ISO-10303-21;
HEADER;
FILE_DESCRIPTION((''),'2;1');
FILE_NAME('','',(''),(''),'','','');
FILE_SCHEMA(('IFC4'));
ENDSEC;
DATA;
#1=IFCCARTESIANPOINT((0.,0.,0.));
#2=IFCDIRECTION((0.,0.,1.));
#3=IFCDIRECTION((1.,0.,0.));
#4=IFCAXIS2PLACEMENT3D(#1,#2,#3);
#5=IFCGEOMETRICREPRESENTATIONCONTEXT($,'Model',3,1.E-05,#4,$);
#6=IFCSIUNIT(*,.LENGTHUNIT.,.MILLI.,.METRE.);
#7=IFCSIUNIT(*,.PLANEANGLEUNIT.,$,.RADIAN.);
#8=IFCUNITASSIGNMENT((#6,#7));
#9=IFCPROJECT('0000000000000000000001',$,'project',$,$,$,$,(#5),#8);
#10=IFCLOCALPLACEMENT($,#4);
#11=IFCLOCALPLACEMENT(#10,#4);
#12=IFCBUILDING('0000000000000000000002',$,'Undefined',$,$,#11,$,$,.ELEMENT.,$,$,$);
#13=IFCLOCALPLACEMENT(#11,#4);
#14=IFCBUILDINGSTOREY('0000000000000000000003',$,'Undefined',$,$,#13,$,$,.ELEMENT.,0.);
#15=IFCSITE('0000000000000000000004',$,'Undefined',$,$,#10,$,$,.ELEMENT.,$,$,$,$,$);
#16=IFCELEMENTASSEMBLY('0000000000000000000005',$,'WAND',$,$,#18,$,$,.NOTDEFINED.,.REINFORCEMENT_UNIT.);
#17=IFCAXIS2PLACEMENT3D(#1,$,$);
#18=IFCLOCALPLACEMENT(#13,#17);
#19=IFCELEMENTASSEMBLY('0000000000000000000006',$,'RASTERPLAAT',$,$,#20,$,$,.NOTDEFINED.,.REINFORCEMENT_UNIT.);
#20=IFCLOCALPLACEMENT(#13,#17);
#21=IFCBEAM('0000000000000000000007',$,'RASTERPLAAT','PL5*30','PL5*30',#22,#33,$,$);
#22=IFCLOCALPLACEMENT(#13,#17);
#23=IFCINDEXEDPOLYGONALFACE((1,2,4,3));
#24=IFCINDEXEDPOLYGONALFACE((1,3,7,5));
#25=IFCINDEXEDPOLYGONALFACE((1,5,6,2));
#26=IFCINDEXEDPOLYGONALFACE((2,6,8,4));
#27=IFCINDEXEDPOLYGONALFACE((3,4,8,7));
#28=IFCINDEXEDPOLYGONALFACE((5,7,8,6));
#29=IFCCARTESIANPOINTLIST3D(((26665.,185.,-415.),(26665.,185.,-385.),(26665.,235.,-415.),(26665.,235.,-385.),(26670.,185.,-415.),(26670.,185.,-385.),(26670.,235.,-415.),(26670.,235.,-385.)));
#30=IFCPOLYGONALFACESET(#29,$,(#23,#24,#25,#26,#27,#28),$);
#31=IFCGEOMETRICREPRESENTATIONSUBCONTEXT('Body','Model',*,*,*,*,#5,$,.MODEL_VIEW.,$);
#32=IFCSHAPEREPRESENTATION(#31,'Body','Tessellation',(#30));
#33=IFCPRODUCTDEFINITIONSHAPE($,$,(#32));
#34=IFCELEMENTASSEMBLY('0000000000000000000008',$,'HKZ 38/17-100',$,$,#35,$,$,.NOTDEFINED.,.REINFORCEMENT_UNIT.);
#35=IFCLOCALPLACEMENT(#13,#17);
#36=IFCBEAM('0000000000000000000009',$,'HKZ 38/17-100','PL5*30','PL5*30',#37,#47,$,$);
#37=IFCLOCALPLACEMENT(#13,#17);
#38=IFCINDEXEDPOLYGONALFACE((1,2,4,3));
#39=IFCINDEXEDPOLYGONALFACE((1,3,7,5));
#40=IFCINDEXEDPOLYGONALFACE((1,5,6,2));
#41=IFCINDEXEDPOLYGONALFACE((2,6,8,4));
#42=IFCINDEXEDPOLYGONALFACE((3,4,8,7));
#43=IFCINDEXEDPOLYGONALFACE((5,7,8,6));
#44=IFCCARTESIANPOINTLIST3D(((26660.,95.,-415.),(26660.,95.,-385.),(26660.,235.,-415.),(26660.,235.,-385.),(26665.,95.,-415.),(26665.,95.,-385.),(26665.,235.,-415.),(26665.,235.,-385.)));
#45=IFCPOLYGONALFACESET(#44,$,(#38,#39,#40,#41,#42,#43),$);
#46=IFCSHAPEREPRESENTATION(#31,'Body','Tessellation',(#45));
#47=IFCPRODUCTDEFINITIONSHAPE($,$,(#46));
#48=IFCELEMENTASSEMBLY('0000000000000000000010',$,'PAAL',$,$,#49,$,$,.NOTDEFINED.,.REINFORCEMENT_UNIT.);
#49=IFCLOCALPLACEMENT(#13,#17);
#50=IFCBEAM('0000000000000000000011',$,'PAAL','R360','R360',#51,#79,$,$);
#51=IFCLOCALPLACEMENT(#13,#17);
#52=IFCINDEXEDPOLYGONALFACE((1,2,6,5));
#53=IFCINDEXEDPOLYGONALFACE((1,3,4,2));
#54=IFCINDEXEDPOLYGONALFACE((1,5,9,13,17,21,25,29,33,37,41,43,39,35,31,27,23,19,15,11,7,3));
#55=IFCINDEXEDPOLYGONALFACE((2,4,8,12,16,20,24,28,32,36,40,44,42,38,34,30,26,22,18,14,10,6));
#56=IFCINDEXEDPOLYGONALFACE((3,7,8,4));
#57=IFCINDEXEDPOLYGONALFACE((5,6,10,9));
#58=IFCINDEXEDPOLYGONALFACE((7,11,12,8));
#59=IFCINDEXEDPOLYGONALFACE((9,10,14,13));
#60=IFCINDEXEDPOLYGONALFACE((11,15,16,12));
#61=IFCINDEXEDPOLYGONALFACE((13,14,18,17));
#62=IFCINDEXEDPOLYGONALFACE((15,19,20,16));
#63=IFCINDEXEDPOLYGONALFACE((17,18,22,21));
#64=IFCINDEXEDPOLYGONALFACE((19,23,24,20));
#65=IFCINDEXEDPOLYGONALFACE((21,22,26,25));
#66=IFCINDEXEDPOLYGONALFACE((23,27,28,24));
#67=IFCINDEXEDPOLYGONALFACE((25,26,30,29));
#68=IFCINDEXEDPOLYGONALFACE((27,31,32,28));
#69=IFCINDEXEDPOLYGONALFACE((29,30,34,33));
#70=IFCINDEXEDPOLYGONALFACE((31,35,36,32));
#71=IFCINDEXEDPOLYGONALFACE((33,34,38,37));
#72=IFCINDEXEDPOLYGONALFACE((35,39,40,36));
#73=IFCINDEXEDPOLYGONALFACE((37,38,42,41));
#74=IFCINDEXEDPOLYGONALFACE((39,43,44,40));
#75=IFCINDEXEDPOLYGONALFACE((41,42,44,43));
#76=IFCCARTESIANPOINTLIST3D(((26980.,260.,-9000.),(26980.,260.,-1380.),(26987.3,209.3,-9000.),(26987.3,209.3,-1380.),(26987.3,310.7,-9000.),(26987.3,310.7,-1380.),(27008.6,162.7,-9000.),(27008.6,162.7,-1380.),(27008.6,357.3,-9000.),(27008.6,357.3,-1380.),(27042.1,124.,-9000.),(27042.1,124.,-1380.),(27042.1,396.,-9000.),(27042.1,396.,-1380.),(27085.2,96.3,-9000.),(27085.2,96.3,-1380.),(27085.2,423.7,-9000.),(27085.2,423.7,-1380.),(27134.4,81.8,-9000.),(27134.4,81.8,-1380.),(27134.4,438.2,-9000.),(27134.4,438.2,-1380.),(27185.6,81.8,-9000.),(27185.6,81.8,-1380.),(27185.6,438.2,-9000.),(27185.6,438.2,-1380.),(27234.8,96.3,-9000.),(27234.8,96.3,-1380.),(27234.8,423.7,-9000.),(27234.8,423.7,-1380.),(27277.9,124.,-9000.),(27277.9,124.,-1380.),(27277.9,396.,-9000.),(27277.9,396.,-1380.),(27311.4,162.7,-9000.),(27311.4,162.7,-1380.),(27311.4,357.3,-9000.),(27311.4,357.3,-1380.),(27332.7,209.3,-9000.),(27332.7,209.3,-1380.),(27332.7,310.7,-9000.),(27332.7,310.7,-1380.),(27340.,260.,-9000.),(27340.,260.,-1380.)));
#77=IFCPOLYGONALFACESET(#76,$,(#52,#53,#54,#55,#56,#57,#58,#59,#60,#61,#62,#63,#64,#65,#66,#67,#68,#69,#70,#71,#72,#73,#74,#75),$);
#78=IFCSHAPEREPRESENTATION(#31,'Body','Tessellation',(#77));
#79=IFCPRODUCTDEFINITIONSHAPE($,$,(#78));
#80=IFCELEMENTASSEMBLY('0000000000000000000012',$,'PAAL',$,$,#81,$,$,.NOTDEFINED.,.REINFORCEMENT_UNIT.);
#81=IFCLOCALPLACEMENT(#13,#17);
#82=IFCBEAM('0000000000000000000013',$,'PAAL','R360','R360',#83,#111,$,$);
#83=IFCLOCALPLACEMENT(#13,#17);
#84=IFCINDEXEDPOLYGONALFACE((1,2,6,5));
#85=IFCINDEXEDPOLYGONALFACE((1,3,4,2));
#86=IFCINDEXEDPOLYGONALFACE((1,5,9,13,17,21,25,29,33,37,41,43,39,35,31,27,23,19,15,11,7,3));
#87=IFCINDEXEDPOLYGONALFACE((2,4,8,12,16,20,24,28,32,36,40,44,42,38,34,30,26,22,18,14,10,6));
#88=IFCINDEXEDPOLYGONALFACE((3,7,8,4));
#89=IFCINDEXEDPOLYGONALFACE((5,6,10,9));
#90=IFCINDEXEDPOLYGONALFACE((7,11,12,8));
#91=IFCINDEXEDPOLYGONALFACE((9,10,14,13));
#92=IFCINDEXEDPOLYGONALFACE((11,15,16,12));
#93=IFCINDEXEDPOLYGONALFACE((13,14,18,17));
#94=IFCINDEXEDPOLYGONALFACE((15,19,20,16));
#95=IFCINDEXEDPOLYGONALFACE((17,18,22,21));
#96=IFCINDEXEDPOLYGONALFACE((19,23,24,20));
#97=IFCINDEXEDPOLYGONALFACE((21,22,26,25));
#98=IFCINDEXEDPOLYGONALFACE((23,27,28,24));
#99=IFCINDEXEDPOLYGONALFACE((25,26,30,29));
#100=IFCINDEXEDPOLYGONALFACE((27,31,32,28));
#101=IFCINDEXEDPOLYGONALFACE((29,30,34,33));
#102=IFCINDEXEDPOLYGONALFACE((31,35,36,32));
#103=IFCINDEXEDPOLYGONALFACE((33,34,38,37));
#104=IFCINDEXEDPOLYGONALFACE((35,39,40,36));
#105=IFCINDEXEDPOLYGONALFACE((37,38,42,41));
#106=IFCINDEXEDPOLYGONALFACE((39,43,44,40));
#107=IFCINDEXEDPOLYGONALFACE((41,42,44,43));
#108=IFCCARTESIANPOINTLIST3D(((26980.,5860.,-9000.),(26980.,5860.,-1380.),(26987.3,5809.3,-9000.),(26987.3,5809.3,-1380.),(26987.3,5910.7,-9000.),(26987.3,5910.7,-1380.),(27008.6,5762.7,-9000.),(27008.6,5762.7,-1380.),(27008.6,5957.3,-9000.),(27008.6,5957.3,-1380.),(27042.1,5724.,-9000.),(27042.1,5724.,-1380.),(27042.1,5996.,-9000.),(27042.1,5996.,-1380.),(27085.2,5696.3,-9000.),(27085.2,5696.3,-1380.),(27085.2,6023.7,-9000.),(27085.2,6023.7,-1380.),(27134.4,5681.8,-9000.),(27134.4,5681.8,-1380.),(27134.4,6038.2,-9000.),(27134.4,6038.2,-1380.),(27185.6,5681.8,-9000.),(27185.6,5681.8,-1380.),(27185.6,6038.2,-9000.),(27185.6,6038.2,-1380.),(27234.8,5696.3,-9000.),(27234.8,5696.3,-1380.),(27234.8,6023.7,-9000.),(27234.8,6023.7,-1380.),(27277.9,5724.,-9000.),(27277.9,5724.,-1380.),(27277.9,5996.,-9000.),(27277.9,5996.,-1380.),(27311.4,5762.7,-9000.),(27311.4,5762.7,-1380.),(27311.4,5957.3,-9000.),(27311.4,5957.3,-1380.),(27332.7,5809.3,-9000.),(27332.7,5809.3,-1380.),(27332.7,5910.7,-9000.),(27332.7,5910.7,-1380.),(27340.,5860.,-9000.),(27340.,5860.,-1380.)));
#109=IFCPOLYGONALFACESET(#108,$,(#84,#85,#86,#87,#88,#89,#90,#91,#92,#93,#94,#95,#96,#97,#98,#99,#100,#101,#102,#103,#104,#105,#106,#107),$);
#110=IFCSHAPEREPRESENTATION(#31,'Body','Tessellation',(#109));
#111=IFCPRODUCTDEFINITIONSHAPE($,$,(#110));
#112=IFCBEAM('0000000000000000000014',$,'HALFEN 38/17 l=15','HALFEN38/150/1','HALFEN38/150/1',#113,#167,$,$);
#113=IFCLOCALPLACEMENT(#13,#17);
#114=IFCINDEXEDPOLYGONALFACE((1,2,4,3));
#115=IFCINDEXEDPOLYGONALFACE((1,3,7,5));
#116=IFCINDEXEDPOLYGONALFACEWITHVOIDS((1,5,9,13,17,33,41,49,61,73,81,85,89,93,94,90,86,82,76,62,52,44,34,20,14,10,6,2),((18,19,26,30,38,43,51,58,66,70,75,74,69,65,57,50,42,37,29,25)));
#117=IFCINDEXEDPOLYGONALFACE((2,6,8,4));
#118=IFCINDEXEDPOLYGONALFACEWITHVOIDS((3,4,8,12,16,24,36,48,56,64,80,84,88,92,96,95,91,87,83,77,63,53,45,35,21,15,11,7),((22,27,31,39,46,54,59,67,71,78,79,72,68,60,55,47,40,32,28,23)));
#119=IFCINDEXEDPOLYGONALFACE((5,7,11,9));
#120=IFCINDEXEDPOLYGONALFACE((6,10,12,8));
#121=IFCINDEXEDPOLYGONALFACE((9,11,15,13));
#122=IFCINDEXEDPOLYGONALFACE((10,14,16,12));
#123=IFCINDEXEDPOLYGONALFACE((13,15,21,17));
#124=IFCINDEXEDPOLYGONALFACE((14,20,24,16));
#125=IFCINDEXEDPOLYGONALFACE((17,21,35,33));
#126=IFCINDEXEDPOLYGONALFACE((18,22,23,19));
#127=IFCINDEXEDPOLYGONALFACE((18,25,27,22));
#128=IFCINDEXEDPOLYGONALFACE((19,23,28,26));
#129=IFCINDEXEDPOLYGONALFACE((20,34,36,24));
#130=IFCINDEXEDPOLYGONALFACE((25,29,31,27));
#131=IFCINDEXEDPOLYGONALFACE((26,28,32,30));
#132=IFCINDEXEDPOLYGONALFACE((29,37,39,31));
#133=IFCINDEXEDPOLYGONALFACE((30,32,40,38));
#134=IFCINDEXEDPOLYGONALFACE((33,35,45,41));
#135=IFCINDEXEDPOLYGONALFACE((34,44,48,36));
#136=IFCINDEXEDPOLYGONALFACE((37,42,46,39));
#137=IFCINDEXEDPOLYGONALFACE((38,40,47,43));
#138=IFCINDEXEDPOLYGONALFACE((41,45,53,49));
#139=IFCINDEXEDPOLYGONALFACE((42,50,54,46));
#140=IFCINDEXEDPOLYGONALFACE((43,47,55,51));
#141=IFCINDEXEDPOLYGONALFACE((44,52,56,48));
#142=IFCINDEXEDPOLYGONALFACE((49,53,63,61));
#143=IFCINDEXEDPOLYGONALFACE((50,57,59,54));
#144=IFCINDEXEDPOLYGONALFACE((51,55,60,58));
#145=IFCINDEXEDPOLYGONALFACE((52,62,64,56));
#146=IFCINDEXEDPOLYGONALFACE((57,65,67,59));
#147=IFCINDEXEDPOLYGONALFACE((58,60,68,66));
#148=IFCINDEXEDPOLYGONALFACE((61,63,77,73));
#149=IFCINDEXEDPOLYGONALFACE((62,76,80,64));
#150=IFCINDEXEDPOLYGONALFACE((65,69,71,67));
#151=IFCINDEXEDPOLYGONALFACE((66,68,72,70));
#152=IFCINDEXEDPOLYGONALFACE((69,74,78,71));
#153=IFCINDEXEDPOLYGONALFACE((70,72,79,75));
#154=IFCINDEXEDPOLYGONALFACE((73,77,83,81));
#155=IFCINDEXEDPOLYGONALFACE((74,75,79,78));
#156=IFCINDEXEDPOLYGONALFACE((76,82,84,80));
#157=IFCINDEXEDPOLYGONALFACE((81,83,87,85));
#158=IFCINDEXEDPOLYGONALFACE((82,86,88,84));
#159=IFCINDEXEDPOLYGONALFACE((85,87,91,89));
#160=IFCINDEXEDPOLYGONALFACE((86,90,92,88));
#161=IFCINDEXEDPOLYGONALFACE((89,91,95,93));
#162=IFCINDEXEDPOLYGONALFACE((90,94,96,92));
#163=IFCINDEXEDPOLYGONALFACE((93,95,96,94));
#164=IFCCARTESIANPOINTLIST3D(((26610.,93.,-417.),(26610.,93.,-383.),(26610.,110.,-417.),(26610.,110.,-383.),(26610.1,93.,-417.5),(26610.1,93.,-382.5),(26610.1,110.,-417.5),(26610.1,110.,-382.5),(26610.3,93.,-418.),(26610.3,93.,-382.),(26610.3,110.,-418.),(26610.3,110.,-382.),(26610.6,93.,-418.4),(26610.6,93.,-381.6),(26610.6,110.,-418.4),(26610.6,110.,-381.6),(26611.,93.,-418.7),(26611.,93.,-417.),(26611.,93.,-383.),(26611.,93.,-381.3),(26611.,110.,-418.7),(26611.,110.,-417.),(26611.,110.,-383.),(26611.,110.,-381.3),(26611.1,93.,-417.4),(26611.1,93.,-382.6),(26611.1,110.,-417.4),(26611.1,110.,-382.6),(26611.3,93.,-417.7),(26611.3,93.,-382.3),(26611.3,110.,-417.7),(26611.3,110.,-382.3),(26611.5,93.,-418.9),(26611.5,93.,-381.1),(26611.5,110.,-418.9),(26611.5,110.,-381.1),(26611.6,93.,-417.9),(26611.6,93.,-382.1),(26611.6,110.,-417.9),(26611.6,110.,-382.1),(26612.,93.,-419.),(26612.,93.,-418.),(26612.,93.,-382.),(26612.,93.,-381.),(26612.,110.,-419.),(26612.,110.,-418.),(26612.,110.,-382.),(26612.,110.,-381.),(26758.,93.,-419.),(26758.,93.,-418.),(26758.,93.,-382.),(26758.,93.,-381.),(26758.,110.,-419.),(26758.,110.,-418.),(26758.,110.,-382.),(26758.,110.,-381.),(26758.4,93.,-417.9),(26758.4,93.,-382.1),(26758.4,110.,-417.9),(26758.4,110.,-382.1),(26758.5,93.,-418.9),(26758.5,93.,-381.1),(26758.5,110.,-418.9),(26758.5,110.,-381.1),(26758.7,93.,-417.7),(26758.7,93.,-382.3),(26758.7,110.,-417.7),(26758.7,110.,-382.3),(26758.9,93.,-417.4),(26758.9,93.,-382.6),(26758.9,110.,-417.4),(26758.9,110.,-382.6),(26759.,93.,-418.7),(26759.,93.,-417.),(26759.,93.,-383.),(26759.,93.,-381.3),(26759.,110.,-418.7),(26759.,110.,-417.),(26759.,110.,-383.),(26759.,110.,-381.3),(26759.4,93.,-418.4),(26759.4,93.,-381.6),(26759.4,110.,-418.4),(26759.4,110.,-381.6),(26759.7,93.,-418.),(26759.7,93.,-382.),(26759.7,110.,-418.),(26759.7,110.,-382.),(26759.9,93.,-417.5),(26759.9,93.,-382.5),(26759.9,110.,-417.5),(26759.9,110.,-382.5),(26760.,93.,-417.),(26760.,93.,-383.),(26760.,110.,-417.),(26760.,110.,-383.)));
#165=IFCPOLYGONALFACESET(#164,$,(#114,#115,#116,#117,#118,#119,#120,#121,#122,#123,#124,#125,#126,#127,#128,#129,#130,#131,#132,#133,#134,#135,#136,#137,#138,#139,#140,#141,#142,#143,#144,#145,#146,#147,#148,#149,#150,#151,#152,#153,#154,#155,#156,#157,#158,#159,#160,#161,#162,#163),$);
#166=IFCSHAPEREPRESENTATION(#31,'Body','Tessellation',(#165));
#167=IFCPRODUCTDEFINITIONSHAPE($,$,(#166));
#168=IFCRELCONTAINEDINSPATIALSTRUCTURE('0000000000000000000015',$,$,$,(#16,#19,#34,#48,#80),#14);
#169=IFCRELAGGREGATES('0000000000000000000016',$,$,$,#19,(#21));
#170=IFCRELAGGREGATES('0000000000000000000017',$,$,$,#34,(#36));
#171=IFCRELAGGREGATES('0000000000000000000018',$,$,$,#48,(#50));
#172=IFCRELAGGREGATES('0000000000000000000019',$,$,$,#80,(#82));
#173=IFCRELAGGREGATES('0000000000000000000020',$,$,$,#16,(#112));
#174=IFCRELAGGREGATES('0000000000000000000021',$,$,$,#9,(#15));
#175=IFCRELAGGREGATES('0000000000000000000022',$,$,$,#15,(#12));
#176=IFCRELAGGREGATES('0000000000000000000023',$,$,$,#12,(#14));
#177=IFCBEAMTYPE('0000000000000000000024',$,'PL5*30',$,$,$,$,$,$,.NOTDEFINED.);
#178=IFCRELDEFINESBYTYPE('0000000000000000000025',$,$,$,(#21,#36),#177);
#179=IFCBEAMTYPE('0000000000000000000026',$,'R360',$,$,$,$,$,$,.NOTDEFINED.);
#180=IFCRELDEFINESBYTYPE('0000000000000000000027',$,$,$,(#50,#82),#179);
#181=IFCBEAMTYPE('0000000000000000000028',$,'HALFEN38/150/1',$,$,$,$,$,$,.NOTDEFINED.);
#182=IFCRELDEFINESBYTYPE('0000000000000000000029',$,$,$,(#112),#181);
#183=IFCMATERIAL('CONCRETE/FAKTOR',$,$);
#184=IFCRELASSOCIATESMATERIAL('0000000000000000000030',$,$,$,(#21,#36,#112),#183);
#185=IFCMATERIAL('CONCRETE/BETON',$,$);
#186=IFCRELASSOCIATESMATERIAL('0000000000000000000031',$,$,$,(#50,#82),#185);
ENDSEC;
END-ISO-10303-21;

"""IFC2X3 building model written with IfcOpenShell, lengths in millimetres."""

from ifc_helpers import new_model, si_unit, frame, frame_2d, origin_with_axes, place, context, subcontext, project, spatial, rectangle, hollow_rectangle, circle, extrude, material, type_object, element, aggregate, save


model = new_model("IFC2X3")

# Units and contexts
model_context = context("Model", 3, precision=1e-05, world=origin_with_axes())
body_context = subcontext(model_context, "Body", "Model", "MODEL_VIEW")
ifc_project = project(units=[si_unit("LENGTHUNIT", "METRE", prefix="MILLI"), si_unit("PLANEANGLEUNIT", "RADIAN")], contexts=[model_context])

# Site, building, storey
site_placement = place(None, origin_with_axes())
site = spatial("IfcSite", under=ifc_project, at=site_placement, Name="Undefined", CompositionType="ELEMENT")
building_placement = place(site_placement, origin_with_axes())
building = spatial("IfcBuilding", under=site, at=building_placement, Name="Undefined", CompositionType="ELEMENT")
storey_placement = place(building_placement, origin_with_axes())
storey = spatial("IfcBuildingStorey", under=building, at=storey_placement, Name="Undefined", CompositionType="ELEMENT", Elevation=0.0)

# Shared definitions
ifc_material_1 = material(Name="CONCRETE/BETON")

# Element assembly
assembly_1_placement = place(storey_placement, origin_with_axes())
assembly_1 = element("IfcElementAssembly", 1, at=assembly_1_placement, inside=storey, Name="WAND", AssemblyPlace="NOTDEFINED", PredefinedType="REINFORCEMENT_UNIT")
ifc_material_2 = material(Name="CONCRETE/FAKTOR")

# Element assemblies, beams
assembly_2_placement = place(storey_placement, origin_with_axes())
assembly_2 = element("IfcElementAssembly", 2, at=assembly_2_placement, inside=storey, Name="RASTERPLAAT", AssemblyPlace="NOTDEFINED", PredefinedType="REINFORCEMENT_UNIT")
beam_type_1 = type_object("IfcBeamType", Name="PL5*30", PredefinedType="NOTDEFINED")
beam_1_placement = place(assembly_2_placement, frame((26667.5, 235.0, -400.0), z_axis=(0.0, 0.0, 1.0), x_axis=(0.0, -1.0, 0.0)))
beam_1 = element("IfcBeam", 3, at=beam_1_placement, type_object=beam_type_1, material=ifc_material_2, Name="RASTERPLAAT", Description="PL5*30", ObjectType="PL5*30", context=body_context, shape_type="SweptSolid", body=[
    extrude(rectangle(XDim=5.0, YDim=30.0, at=frame_2d((0.0, 0.0), x_axis=(1.0, 0.0))), frame((50.0, 0.0, 0.0), z_axis=(-1.0, 0.0, 0.0), x_axis=(0.0, -1.0, 0.0)), (0.0, 0.0, 1.0), 50.0),
])
aggregate(assembly_2, [beam_1])
assembly_3_placement = place(storey_placement, origin_with_axes())
assembly_3 = element("IfcElementAssembly", 4, at=assembly_3_placement, inside=storey, Name="HKZ 38/17-100", AssemblyPlace="NOTDEFINED", PredefinedType="REINFORCEMENT_UNIT")
beam_2_placement = place(assembly_3_placement, frame((26662.5, 95.0, -400.0), z_axis=(0.0, 0.0, 1.0), x_axis=(0.0, 1.0, 0.0)))
beam_2 = element("IfcBeam", 5, at=beam_2_placement, type_object=beam_type_1, material=ifc_material_2, Name="HKZ 38/17-100", Description="PL5*30", ObjectType="PL5*30", context=body_context, shape_type="SweptSolid", body=[
    extrude(rectangle(XDim=5.0, YDim=30.0, at=frame_2d((0.0, 0.0), x_axis=(1.0, 0.0))), frame((140.0, 0.0, 0.0), z_axis=(-1.0, 0.0, 0.0), x_axis=(0.0, -1.0, 0.0)), (0.0, 0.0, 1.0), 140.0),
])
aggregate(assembly_3, [beam_2])
assembly_4_placement = place(storey_placement, origin_with_axes())
assembly_4 = element("IfcElementAssembly", 6, at=assembly_4_placement, inside=storey, Name="PAAL", AssemblyPlace="NOTDEFINED", PredefinedType="REINFORCEMENT_UNIT")
beam_type_2 = type_object("IfcBeamType", Name="R360", PredefinedType="NOTDEFINED")
beam_3_placement = place(assembly_4_placement, frame((27160.0, 260.0, -1380.0), z_axis=(0.0, -1.0, 0.0), x_axis=(0.0, 0.0, -1.0)))
beam_3 = element("IfcBeam", 7, at=beam_3_placement, type_object=beam_type_2, material=ifc_material_1, Name="PAAL", Description="R360", ObjectType="R360", context=body_context, shape_type="SweptSolid", body=[
    extrude(circle(Radius=180.0, at=frame_2d((0.0, 0.0), x_axis=(1.0, 0.0))), frame((7620.0, 0.0, 0.0), z_axis=(-1.0, 0.0, 0.0), x_axis=(0.0, -1.0, 0.0)), (0.0, 0.0, 1.0), 7620.0),
])
aggregate(assembly_4, [beam_3])
assembly_5_placement = place(storey_placement, origin_with_axes())
assembly_5 = element("IfcElementAssembly", 8, at=assembly_5_placement, inside=storey, Name="PAAL", AssemblyPlace="NOTDEFINED", PredefinedType="REINFORCEMENT_UNIT")
beam_4_placement = place(assembly_5_placement, frame((27160.0, 5860.0, -1380.0), z_axis=(0.0, -1.0, 0.0), x_axis=(0.0, 0.0, -1.0)))
beam_4 = element("IfcBeam", 9, at=beam_4_placement, type_object=beam_type_2, material=ifc_material_1, Name="PAAL", Description="R360", ObjectType="R360", context=body_context, shape_type="SweptSolid", body=[
    extrude(circle(Radius=180.0, at=frame_2d((0.0, 0.0), x_axis=(1.0, 0.0))), frame((7620.0, 0.0, 0.0), z_axis=(-1.0, 0.0, 0.0), x_axis=(0.0, -1.0, 0.0)), (0.0, 0.0, 1.0), 7620.0),
])
aggregate(assembly_5, [beam_4])

# Beam
beam_type_3 = type_object("IfcBeamType", Name="HALFEN38/150/1", PredefinedType="NOTDEFINED")
beam_5_placement = place(assembly_1_placement, frame((26685.0, 110.0, -400.0), z_axis=(0.0, 0.0, -1.0), x_axis=(0.0, -1.0, 0.0)))
beam_5 = element("IfcBeam", 10, at=beam_5_placement, type_object=beam_type_3, material=ifc_material_2, Name="HALFEN 38/17 l=15", Description="HALFEN38/150/1", ObjectType="HALFEN38/150/1", context=body_context, shape_type="SweptSolid", body=[
    extrude(hollow_rectangle(XDim=150.0, YDim=38.0, WallThickness=1.0, InnerFilletRadius=1.0, OuterFilletRadius=2.0, at=frame_2d((0.0, 0.0), x_axis=(1.0, 0.0))), frame((17.0, 0.0, 0.0), z_axis=(-1.0, 0.0, 0.0), x_axis=(0.0, -1.0, 0.0)), (0.0, 0.0, 1.0), 17.0),
])

aggregate(assembly_1, [beam_5])

save(model, "model.ifc")
